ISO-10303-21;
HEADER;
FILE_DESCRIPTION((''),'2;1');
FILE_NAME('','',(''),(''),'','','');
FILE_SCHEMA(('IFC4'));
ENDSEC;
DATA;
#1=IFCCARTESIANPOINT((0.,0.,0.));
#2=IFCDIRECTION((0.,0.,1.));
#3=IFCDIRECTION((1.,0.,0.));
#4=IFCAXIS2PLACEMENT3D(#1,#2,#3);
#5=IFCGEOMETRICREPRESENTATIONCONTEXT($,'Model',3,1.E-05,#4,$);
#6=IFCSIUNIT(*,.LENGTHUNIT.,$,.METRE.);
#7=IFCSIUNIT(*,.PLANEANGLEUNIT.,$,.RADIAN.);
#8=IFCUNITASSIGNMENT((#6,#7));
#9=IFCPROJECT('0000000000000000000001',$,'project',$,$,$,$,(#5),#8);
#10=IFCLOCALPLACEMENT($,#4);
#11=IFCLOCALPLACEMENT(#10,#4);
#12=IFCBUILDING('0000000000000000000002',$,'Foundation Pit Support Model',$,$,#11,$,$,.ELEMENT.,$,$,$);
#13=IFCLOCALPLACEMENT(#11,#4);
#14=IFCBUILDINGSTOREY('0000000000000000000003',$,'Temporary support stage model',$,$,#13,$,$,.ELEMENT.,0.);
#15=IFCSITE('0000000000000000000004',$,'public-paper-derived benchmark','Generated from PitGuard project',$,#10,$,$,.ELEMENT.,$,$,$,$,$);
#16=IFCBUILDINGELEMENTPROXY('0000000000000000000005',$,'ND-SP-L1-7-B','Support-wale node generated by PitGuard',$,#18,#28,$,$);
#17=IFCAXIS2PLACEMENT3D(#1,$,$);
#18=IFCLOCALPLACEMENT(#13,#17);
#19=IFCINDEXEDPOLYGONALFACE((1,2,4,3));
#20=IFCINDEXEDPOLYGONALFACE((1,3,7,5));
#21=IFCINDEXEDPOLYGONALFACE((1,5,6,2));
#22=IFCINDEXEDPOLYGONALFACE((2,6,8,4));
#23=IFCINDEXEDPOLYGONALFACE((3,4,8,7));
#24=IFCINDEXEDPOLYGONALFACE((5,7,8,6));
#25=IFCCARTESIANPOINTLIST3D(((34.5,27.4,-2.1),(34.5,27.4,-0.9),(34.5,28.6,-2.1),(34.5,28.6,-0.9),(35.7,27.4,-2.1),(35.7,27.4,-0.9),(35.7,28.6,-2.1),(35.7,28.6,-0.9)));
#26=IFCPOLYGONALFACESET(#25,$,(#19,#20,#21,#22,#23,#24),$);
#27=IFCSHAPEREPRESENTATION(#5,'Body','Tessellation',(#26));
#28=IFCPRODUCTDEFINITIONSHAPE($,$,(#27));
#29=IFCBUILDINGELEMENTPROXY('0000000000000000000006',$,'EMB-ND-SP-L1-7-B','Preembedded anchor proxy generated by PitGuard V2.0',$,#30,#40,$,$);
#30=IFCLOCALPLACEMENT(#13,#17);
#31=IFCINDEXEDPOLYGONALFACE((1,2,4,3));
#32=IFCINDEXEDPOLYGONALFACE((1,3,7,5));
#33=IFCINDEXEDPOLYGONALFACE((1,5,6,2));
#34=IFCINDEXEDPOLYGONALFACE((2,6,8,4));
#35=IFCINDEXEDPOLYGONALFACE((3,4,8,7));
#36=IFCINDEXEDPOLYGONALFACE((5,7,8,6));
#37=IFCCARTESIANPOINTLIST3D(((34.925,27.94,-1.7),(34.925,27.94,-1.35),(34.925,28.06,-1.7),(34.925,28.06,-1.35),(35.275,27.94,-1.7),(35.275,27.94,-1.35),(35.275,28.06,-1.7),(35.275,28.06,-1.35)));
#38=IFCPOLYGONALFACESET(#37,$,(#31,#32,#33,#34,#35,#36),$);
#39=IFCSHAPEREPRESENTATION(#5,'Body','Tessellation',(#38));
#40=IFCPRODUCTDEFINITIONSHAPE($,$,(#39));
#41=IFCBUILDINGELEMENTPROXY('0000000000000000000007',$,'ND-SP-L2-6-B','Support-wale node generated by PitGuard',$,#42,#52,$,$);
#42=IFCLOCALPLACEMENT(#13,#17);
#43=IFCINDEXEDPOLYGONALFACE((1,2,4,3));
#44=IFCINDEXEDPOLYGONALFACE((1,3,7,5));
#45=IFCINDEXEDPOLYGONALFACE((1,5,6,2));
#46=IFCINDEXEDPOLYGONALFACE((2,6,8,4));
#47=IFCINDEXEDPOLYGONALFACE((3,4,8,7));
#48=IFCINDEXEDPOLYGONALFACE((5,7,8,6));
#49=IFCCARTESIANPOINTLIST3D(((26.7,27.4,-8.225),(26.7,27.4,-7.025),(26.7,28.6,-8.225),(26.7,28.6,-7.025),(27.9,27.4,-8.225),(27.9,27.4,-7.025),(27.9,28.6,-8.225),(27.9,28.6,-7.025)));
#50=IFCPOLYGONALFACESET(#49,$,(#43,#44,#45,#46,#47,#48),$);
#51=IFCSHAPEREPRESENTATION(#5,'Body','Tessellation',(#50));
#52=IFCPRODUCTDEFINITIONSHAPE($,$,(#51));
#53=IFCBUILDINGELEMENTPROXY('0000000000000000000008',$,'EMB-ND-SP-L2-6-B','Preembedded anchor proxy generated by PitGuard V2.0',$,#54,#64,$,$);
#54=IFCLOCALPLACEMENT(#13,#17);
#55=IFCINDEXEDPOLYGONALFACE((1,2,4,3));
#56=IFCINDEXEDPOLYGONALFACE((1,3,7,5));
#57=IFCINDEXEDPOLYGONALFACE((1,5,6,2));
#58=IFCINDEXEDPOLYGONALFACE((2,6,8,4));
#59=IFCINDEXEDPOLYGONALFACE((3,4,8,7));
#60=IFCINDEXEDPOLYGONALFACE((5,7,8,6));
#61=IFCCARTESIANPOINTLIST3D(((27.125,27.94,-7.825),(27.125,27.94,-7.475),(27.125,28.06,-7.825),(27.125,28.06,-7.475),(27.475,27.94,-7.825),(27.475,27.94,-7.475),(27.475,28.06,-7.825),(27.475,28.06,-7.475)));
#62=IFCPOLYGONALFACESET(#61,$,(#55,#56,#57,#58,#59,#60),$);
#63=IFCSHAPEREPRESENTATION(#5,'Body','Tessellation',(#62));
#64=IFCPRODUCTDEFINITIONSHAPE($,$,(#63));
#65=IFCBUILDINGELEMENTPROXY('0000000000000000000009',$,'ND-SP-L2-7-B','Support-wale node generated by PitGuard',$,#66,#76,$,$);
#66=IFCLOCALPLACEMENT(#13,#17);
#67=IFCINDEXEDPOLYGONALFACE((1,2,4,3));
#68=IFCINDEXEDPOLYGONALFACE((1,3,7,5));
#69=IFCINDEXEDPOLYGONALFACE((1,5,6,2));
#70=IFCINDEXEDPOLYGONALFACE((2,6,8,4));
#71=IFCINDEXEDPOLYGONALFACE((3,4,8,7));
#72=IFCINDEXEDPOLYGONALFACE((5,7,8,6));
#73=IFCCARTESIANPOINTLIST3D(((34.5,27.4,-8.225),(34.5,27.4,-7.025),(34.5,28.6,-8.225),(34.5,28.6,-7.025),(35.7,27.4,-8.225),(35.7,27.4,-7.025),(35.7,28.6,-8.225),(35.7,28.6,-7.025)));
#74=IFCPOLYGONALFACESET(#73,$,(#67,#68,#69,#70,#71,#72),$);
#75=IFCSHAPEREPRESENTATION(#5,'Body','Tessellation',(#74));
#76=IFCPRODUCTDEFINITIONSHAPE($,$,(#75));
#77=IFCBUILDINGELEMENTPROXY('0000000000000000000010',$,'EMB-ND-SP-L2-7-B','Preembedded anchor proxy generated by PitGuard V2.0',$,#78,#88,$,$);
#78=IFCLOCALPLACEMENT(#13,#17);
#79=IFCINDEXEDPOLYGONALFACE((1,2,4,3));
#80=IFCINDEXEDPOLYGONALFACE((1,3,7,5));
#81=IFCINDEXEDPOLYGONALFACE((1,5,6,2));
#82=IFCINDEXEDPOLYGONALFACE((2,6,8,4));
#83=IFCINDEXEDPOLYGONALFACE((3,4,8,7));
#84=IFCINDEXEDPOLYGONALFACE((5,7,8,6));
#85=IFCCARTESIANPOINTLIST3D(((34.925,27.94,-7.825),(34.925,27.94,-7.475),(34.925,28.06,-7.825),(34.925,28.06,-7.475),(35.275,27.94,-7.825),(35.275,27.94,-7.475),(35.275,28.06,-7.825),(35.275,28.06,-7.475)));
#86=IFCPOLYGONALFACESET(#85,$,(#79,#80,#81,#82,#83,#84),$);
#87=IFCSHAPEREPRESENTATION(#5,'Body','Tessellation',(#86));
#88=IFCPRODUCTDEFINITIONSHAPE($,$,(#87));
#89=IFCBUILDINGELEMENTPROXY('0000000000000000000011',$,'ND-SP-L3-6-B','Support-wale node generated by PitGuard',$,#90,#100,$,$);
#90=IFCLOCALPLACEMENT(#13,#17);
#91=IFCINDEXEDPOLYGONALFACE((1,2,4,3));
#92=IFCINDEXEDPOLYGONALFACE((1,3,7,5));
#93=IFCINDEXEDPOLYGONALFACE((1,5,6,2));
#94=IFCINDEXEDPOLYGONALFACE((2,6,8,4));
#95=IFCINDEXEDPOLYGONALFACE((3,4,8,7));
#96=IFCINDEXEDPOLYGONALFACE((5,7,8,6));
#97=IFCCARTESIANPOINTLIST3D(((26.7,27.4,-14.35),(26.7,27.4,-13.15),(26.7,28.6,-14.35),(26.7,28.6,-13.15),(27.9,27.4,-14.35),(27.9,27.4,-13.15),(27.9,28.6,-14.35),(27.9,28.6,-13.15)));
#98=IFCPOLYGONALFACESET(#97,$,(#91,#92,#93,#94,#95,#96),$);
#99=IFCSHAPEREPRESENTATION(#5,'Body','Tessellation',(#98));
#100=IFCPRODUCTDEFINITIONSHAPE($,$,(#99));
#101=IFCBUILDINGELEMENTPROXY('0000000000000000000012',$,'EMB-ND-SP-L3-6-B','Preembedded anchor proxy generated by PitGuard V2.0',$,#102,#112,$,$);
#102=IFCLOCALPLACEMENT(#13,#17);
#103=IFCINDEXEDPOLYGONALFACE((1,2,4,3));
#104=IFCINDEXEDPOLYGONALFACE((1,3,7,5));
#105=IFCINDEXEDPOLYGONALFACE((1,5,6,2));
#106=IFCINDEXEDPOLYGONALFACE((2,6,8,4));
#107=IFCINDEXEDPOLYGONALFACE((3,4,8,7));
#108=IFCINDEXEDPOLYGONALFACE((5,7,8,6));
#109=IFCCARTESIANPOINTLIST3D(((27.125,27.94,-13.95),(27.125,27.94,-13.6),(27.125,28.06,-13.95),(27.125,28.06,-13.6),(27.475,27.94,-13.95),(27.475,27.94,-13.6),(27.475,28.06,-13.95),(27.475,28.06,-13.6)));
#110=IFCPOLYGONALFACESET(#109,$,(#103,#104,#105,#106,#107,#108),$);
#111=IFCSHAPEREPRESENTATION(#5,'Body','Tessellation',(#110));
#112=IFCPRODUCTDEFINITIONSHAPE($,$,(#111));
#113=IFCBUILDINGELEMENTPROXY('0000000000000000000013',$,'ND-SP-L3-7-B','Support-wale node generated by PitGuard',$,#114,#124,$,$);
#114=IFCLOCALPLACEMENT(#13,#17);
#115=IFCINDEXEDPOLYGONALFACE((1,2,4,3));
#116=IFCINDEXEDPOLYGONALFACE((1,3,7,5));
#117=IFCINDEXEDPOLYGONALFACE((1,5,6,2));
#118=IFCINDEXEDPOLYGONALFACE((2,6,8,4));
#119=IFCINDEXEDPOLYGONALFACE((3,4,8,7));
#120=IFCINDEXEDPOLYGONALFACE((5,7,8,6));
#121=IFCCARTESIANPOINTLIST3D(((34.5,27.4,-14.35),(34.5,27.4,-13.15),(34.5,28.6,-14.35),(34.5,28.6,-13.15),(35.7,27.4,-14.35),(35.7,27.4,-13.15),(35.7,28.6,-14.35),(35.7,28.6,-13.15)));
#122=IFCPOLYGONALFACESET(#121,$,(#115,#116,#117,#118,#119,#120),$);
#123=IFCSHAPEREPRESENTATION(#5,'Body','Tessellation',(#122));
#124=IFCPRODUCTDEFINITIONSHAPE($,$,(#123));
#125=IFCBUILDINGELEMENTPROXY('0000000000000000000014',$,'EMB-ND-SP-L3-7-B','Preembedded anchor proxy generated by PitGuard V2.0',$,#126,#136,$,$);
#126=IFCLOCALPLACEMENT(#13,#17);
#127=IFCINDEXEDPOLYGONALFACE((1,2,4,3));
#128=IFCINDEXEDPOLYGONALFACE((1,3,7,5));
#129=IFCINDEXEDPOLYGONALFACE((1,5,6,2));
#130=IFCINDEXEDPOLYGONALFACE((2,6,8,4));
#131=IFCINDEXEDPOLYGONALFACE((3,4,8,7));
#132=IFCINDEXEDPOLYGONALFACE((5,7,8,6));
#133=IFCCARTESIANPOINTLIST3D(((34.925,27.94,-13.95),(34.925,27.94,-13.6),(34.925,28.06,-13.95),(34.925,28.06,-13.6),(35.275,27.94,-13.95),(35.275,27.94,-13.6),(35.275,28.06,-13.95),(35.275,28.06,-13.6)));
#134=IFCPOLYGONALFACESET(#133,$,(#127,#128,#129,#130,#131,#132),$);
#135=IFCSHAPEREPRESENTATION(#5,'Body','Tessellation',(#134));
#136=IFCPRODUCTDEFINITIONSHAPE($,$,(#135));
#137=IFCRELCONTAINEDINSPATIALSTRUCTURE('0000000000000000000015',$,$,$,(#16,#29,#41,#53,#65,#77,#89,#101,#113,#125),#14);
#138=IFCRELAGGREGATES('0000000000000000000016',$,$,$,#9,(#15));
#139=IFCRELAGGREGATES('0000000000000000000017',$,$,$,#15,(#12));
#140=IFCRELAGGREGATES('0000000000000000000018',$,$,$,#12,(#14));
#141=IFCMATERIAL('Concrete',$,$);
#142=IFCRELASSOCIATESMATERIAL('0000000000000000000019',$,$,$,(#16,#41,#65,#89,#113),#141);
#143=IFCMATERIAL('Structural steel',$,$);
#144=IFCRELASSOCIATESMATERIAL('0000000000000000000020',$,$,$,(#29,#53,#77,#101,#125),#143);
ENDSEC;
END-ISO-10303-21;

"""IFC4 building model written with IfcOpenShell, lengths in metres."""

from ifc_helpers import new_model, si_unit, frame, origin_with_axes, origin_2d, place, context, project, spatial, rectangle, extrude, material, element, save


model = new_model("IFC4")

# Units and contexts
model_context = context("Model", 3, precision=1e-05, world=origin_with_axes())
ifc_project = project(units=[si_unit("LENGTHUNIT", "METRE"), si_unit("PLANEANGLEUNIT", "RADIAN")], contexts=[model_context])

# Site, building, storey
site_placement = place(None, origin_with_axes())
site = spatial("IfcSite", under=ifc_project, at=site_placement, Name="public-paper-derived benchmark", Description="Generated from PitGuard project", CompositionType="ELEMENT")
building_placement = place(site_placement, origin_with_axes())
building = spatial("IfcBuilding", under=site, at=building_placement, Name="Foundation Pit Support Model", CompositionType="ELEMENT")
storey_placement = place(building_placement, origin_with_axes())
storey = spatial("IfcBuildingStorey", under=building, at=storey_placement, Name="Temporary support stage model", CompositionType="ELEMENT", Elevation=0.0)

# Shared definitions
ifc_material_1 = material(Name="Concrete")

# Shared definitions
ifc_material_2 = material(Name="Structural steel")

# Building element proxies
proxy_1_placement = place(storey_placement, frame((35.1, 28.0, -2.1), z_axis=(0.0, 0.0, 1.0), x_axis=(1.0, 0.0, 0.0)))
element("IfcBuildingElementProxy", 1, at=proxy_1_placement, inside=storey, material=ifc_material_1, Name="ND-SP-L1-7-B", Description="Support-wale node generated by PitGuard", context=model_context, shape_type="SweptSolid", body=[
    extrude(rectangle(XDim=1.2, YDim=1.2, at=origin_2d()), origin_with_axes(), (0.0, 0.0, 1.0), 1.2),
])
proxy_2_placement = place(storey_placement, frame((35.1, 28.0, -1.7), z_axis=(0.0, 0.0, 1.0), x_axis=(1.0, 0.0, 0.0)))
element("IfcBuildingElementProxy", 2, at=proxy_2_placement, inside=storey, material=ifc_material_2, Name="EMB-ND-SP-L1-7-B", Description="Preembedded anchor proxy generated by PitGuard V2.0", context=model_context, shape_type="SweptSolid", body=[
    extrude(rectangle(XDim=0.35, YDim=0.12, at=origin_2d()), origin_with_axes(), (0.0, 0.0, 1.0), 0.35),
])
proxy_3_placement = place(storey_placement, frame((27.3, 28.0, -8.225), z_axis=(0.0, 0.0, 1.0), x_axis=(1.0, 0.0, 0.0)))
element("IfcBuildingElementProxy", 3, at=proxy_3_placement, inside=storey, material=ifc_material_1, Name="ND-SP-L2-6-B", Description="Support-wale node generated by PitGuard", context=model_context, shape_type="SweptSolid", body=[
    extrude(rectangle(XDim=1.2, YDim=1.2, at=origin_2d()), origin_with_axes(), (0.0, 0.0, 1.0), 1.2),
])
proxy_4_placement = place(storey_placement, frame((27.3, 28.0, -7.825), z_axis=(0.0, 0.0, 1.0), x_axis=(1.0, 0.0, 0.0)))
element("IfcBuildingElementProxy", 4, at=proxy_4_placement, inside=storey, material=ifc_material_2, Name="EMB-ND-SP-L2-6-B", Description="Preembedded anchor proxy generated by PitGuard V2.0", context=model_context, shape_type="SweptSolid", body=[
    extrude(rectangle(XDim=0.35, YDim=0.12, at=origin_2d()), origin_with_axes(), (0.0, 0.0, 1.0), 0.35),
])
proxy_5_placement = place(storey_placement, frame((35.1, 28.0, -8.225), z_axis=(0.0, 0.0, 1.0), x_axis=(1.0, 0.0, 0.0)))
element("IfcBuildingElementProxy", 5, at=proxy_5_placement, inside=storey, material=ifc_material_1, Name="ND-SP-L2-7-B", Description="Support-wale node generated by PitGuard", context=model_context, shape_type="SweptSolid", body=[
    extrude(rectangle(XDim=1.2, YDim=1.2, at=origin_2d()), origin_with_axes(), (0.0, 0.0, 1.0), 1.2),
])
proxy_6_placement = place(storey_placement, frame((35.1, 28.0, -7.825), z_axis=(0.0, 0.0, 1.0), x_axis=(1.0, 0.0, 0.0)))
element("IfcBuildingElementProxy", 6, at=proxy_6_placement, inside=storey, material=ifc_material_2, Name="EMB-ND-SP-L2-7-B", Description="Preembedded anchor proxy generated by PitGuard V2.0", context=model_context, shape_type="SweptSolid", body=[
    extrude(rectangle(XDim=0.35, YDim=0.12, at=origin_2d()), origin_with_axes(), (0.0, 0.0, 1.0), 0.35),
])
proxy_7_placement = place(storey_placement, frame((27.3, 28.0, -14.35), z_axis=(0.0, 0.0, 1.0), x_axis=(1.0, 0.0, 0.0)))
element("IfcBuildingElementProxy", 7, at=proxy_7_placement, inside=storey, material=ifc_material_1, Name="ND-SP-L3-6-B", Description="Support-wale node generated by PitGuard", context=model_context, shape_type="SweptSolid", body=[
    extrude(rectangle(XDim=1.2, YDim=1.2, at=origin_2d()), origin_with_axes(), (0.0, 0.0, 1.0), 1.2),
])
proxy_8_placement = place(storey_placement, frame((27.3, 28.0, -13.95), z_axis=(0.0, 0.0, 1.0), x_axis=(1.0, 0.0, 0.0)))
element("IfcBuildingElementProxy", 8, at=proxy_8_placement, inside=storey, material=ifc_material_2, Name="EMB-ND-SP-L3-6-B", Description="Preembedded anchor proxy generated by PitGuard V2.0", context=model_context, shape_type="SweptSolid", body=[
    extrude(rectangle(XDim=0.35, YDim=0.12, at=origin_2d()), origin_with_axes(), (0.0, 0.0, 1.0), 0.35),
])
proxy_9_placement = place(storey_placement, frame((35.1, 28.0, -14.35), z_axis=(0.0, 0.0, 1.0), x_axis=(1.0, 0.0, 0.0)))
element("IfcBuildingElementProxy", 9, at=proxy_9_placement, inside=storey, material=ifc_material_1, Name="ND-SP-L3-7-B", Description="Support-wale node generated by PitGuard", context=model_context, shape_type="SweptSolid", body=[
    extrude(rectangle(XDim=1.2, YDim=1.2, at=origin_2d()), origin_with_axes(), (0.0, 0.0, 1.0), 1.2),
])
proxy_10_placement = place(storey_placement, frame((35.1, 28.0, -13.95), z_axis=(0.0, 0.0, 1.0), x_axis=(1.0, 0.0, 0.0)))
element("IfcBuildingElementProxy", 10, at=proxy_10_placement, inside=storey, material=ifc_material_2, Name="EMB-ND-SP-L3-7-B", Description="Preembedded anchor proxy generated by PitGuard V2.0", context=model_context, shape_type="SweptSolid", body=[
    extrude(rectangle(XDim=0.35, YDim=0.12, at=origin_2d()), origin_with_axes(), (0.0, 0.0, 1.0), 0.35),
])

save(model, "model.ifc")
